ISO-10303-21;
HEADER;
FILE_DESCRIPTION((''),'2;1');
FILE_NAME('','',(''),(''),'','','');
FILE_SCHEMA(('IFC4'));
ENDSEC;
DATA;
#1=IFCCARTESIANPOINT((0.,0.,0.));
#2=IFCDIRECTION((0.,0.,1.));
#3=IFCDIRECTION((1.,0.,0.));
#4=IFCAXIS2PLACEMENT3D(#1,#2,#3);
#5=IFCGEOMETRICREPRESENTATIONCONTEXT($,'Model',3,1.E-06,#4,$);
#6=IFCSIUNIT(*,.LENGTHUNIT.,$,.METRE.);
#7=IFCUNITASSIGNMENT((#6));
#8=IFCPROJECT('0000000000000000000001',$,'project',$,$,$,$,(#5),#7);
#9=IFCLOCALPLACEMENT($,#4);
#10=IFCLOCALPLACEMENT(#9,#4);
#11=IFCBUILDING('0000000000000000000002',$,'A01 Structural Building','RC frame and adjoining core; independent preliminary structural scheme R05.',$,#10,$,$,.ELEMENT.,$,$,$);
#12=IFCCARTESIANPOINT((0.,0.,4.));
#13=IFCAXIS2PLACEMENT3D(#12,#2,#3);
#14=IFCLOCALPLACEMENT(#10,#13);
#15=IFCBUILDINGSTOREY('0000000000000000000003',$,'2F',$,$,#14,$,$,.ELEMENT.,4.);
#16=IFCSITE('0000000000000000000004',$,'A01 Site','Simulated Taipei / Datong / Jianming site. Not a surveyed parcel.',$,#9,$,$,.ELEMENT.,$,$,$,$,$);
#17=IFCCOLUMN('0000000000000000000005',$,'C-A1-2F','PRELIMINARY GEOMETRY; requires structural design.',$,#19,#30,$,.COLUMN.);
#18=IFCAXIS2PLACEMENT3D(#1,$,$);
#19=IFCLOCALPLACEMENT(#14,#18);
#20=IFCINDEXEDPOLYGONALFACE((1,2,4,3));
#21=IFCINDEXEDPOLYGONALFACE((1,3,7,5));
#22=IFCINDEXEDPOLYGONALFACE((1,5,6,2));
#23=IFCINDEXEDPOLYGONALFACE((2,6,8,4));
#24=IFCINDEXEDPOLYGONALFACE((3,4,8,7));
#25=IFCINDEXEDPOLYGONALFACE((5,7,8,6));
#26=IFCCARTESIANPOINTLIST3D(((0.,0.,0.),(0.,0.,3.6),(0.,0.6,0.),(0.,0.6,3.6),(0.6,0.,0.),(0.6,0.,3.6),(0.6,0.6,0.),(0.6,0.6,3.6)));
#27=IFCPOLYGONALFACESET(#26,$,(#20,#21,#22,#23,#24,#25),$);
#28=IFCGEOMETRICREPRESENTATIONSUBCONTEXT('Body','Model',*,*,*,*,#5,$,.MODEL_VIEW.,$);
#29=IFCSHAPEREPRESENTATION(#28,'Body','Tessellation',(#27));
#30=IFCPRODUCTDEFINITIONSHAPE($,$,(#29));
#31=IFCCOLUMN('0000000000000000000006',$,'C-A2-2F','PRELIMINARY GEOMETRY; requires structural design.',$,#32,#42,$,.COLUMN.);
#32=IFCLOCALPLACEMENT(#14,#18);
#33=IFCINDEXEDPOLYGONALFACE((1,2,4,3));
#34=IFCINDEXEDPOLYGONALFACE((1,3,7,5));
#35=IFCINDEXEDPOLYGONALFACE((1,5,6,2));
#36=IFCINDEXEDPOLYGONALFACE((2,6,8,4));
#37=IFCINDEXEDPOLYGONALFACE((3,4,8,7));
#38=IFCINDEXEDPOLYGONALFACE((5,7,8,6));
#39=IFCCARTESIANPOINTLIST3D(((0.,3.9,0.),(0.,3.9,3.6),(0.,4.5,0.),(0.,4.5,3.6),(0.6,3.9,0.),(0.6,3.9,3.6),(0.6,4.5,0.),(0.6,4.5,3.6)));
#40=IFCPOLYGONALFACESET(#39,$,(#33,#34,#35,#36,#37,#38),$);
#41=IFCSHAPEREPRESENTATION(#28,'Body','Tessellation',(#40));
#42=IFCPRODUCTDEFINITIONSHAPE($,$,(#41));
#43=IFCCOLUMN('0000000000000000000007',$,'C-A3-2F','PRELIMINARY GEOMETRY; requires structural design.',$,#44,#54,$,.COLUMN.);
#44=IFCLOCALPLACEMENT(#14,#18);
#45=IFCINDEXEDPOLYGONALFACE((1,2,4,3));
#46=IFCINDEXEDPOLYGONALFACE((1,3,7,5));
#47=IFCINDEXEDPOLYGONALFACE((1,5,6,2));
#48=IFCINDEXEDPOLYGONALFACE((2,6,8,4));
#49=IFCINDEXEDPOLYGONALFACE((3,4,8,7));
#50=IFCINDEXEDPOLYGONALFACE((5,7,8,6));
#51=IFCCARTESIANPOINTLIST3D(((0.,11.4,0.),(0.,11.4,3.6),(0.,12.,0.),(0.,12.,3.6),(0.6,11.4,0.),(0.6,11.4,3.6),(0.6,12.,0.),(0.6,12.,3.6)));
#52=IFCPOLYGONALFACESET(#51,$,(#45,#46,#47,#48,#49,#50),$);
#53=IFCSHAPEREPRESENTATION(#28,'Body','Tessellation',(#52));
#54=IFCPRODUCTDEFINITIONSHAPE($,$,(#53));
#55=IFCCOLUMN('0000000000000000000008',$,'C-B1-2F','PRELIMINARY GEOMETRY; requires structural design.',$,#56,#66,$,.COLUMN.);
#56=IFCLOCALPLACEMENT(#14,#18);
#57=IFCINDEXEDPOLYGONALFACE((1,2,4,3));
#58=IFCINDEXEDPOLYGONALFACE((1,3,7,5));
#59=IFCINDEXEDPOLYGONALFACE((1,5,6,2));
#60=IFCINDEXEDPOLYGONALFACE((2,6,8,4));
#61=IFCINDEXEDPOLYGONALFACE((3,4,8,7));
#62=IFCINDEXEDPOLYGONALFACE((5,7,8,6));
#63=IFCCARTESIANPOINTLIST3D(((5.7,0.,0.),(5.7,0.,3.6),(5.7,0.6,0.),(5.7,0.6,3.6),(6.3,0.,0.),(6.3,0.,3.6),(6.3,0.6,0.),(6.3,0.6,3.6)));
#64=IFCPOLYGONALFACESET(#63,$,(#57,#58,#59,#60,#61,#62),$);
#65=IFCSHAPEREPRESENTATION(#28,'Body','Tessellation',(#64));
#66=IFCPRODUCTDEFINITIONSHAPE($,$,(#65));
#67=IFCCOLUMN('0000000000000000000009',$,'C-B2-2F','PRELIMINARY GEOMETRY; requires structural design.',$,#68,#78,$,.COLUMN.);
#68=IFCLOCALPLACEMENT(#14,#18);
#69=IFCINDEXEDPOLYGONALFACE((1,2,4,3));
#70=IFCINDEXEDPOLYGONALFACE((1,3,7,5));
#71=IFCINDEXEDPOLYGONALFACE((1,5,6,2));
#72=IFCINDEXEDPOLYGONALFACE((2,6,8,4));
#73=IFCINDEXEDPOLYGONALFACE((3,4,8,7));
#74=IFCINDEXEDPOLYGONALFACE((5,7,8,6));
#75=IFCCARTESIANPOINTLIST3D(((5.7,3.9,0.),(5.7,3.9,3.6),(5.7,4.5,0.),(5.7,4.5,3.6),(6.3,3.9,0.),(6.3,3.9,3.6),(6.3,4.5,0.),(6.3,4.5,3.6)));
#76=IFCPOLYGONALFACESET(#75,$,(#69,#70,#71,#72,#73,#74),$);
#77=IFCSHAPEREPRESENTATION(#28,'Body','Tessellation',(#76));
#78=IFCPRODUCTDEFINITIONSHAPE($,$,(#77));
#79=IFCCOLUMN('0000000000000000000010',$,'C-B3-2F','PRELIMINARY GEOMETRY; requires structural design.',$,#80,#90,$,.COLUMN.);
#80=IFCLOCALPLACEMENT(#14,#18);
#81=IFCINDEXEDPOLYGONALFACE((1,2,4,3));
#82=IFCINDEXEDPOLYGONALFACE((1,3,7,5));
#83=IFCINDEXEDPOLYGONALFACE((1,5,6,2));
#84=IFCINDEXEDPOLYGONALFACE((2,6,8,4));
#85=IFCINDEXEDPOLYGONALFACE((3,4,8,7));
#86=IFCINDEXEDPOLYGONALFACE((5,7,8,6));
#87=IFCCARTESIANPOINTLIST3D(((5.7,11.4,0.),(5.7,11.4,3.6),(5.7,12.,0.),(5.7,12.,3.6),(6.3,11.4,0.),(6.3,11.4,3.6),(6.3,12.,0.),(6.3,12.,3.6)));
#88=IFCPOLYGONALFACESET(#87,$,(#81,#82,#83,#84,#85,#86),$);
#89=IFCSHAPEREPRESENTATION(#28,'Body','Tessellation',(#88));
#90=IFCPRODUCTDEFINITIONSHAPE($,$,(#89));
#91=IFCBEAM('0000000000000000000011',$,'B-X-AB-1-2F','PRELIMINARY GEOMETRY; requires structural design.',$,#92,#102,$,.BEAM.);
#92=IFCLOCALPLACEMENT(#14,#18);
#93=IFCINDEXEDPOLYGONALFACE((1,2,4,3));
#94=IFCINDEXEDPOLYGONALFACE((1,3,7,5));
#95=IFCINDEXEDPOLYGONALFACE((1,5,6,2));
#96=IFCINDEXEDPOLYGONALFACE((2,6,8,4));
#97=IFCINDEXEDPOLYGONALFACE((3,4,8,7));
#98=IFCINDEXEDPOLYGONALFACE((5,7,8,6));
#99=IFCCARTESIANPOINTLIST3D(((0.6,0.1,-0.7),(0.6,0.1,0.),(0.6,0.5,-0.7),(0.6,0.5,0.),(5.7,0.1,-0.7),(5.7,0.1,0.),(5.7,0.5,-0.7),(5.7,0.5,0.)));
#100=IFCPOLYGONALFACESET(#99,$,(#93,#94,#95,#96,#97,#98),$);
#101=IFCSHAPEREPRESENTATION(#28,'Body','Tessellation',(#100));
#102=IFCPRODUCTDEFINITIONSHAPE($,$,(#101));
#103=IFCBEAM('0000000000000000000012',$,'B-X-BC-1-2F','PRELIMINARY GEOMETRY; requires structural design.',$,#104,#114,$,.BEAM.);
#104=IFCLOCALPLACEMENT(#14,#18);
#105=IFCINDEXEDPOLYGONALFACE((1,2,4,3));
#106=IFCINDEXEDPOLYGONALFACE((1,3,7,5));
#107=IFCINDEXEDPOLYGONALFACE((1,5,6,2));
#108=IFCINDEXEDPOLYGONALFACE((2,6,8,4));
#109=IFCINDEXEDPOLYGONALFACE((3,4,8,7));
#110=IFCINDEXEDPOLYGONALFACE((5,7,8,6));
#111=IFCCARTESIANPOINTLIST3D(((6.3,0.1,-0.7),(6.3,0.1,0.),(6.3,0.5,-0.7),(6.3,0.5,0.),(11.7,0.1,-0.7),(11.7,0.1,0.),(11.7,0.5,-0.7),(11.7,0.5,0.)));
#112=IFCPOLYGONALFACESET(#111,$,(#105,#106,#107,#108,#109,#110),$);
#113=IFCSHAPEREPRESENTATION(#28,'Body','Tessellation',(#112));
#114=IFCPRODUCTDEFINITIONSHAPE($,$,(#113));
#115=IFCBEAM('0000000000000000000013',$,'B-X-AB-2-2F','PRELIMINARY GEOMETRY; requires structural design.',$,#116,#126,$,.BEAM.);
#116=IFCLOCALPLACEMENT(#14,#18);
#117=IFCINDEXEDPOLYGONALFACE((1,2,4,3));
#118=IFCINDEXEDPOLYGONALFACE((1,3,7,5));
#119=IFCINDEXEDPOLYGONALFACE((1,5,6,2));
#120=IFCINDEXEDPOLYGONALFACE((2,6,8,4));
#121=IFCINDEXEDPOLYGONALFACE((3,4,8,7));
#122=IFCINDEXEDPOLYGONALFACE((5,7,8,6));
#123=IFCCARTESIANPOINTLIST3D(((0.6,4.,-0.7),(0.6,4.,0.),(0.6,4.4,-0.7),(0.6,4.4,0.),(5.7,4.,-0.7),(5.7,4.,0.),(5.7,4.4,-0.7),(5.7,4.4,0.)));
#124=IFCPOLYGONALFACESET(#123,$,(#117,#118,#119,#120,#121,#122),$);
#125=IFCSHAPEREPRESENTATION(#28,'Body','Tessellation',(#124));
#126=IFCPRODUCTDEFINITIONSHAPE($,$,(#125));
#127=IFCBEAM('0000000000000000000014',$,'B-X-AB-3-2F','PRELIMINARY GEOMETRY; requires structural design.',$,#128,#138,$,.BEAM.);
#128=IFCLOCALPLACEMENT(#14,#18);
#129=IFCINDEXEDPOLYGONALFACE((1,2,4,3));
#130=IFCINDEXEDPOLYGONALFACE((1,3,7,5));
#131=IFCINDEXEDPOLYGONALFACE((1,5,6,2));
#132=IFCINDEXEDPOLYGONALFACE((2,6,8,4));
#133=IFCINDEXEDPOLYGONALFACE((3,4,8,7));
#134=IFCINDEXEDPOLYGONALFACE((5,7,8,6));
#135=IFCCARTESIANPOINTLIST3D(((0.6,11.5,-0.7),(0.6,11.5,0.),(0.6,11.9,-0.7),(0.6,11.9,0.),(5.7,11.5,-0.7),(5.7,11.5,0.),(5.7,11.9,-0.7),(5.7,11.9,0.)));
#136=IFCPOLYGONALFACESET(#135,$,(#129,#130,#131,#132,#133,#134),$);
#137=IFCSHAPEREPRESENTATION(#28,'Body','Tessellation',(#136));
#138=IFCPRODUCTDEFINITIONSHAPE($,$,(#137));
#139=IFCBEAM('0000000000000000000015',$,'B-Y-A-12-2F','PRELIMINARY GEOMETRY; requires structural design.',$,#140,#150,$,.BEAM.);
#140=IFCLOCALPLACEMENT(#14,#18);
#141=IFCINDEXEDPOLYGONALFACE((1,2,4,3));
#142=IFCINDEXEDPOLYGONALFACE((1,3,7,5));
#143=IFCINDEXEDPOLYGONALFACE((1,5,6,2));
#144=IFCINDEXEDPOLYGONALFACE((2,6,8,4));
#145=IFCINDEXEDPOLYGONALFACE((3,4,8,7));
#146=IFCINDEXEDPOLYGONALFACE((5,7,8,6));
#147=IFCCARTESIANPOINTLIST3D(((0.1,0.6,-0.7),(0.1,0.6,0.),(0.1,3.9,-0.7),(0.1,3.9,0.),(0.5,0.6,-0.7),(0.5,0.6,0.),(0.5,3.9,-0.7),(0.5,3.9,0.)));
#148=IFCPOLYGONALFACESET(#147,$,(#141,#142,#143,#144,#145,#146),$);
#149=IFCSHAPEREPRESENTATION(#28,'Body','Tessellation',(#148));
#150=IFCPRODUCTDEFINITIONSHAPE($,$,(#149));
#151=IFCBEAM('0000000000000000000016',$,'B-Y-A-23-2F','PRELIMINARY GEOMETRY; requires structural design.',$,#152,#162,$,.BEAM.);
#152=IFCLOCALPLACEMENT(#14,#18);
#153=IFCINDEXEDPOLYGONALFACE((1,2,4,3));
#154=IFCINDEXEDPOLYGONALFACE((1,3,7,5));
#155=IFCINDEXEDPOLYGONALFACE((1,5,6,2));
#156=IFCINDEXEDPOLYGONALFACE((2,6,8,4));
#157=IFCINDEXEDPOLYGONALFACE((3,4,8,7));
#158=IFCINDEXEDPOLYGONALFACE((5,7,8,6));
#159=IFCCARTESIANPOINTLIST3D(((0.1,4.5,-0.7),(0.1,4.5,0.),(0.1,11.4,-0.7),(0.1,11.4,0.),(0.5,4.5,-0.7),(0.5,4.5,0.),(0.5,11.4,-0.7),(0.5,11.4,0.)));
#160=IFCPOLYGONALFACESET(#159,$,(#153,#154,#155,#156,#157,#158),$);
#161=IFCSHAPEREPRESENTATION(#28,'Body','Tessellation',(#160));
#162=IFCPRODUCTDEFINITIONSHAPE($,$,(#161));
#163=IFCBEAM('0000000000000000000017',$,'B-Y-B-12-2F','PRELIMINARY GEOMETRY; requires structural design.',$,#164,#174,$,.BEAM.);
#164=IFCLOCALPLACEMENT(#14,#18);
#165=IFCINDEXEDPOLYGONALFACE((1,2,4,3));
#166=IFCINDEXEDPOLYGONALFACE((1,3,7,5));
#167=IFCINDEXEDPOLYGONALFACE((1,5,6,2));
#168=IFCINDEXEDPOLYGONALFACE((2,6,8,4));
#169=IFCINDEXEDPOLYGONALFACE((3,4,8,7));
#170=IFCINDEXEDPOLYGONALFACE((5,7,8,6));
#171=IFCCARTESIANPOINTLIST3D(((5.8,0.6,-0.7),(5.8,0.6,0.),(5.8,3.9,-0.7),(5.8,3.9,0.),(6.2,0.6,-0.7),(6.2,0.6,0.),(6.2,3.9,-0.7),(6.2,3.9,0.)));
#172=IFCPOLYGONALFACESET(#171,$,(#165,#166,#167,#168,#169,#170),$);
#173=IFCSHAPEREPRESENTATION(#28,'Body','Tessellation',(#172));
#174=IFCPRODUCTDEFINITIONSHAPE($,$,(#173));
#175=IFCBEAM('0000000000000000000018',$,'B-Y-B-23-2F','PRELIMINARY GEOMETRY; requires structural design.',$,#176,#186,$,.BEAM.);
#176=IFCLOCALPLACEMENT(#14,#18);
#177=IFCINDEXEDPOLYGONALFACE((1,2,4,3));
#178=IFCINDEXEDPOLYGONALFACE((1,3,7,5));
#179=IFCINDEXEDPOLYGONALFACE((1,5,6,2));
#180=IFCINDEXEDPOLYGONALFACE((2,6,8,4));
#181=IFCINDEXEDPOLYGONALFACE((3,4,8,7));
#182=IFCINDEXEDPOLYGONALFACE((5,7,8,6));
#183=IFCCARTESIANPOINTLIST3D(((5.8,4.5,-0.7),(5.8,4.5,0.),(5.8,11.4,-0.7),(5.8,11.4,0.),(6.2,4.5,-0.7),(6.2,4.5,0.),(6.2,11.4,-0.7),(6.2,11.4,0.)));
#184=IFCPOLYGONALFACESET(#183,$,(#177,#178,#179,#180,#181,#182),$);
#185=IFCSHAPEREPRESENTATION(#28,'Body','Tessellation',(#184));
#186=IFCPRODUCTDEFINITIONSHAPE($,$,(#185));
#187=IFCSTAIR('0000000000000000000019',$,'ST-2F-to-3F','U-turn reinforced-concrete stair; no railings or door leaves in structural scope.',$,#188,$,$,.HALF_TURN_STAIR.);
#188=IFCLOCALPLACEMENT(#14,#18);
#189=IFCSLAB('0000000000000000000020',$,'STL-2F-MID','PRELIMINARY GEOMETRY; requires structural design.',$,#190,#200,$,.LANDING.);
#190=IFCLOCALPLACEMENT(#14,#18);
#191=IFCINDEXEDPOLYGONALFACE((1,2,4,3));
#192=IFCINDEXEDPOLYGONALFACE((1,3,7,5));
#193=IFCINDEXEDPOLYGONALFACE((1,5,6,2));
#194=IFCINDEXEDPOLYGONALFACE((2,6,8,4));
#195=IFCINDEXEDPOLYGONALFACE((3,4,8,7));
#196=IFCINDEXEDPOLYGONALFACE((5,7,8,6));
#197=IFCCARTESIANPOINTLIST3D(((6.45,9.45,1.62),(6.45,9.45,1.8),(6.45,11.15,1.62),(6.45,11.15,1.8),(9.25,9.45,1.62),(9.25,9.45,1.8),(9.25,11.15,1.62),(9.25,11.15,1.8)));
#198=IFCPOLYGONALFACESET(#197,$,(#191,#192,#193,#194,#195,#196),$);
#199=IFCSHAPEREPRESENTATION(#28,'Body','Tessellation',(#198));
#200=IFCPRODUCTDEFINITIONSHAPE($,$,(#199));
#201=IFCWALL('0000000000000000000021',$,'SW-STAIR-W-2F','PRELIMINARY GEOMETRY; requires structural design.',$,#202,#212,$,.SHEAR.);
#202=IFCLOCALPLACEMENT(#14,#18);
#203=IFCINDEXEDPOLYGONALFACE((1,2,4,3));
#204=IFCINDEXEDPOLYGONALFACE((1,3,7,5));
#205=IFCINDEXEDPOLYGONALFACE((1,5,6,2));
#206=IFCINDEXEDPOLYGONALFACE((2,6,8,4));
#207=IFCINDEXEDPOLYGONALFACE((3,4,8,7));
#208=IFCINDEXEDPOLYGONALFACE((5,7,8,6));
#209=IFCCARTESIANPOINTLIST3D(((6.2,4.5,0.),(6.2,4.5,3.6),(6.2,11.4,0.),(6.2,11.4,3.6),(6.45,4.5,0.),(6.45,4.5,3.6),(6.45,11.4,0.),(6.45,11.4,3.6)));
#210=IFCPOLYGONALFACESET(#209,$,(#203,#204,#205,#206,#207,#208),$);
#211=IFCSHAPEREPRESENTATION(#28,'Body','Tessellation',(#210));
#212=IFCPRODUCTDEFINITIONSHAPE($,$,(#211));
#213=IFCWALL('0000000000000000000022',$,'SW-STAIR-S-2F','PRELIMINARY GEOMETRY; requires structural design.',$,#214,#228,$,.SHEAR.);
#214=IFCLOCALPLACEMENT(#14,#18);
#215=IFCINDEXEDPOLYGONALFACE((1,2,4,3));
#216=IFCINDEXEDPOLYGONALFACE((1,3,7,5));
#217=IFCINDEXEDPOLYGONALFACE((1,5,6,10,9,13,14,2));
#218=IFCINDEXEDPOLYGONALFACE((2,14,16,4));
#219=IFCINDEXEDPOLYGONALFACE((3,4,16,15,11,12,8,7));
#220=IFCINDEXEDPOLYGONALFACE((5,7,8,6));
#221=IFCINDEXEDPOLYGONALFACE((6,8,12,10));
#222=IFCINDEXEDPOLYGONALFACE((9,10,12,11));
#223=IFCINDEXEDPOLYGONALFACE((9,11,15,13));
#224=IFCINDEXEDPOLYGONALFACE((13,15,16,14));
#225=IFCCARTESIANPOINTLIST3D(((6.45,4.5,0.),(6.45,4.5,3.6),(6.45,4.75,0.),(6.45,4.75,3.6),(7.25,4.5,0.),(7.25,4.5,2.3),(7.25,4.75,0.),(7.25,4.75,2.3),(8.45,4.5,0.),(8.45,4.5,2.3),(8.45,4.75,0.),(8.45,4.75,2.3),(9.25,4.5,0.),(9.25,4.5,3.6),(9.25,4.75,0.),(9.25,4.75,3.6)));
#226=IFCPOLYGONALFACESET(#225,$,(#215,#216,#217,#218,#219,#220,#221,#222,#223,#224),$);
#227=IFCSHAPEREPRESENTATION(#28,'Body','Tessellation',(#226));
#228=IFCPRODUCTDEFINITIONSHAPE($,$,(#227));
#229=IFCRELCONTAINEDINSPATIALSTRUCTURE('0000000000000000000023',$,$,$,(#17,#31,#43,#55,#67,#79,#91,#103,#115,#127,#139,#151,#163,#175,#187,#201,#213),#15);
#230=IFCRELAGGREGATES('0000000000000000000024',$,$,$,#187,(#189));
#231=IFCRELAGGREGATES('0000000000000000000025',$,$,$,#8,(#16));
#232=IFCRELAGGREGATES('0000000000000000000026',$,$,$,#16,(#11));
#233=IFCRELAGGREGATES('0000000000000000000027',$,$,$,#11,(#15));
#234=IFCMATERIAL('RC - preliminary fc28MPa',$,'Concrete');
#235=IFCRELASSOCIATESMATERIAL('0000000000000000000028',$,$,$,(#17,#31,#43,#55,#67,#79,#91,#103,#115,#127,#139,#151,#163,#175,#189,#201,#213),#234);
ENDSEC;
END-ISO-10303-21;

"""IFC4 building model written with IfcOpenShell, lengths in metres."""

from ifc_helpers import new_model, si_unit, frame, origin_with_axes, place, context, subcontext, project, spatial, rectangle, extrude, material, element, aggregate, save


model = new_model("IFC4")

# Units and contexts
model_context = context("Model", 3, precision=1e-06, world=origin_with_axes())
body_context = subcontext(model_context, "Body", "Model", "MODEL_VIEW")
ifc_project = project(units=[si_unit("LENGTHUNIT", "METRE")], contexts=[model_context])

# Site, building, storey
site_placement = place(None, origin_with_axes())
site = spatial("IfcSite", under=ifc_project, at=site_placement, Name="A01 Site", Description="Simulated Taipei / Datong / Jianming site. Not a surveyed parcel.", CompositionType="ELEMENT")
building_placement = place(site_placement, origin_with_axes())
building = spatial("IfcBuilding", under=site, at=building_placement, Name="A01 Structural Building", Description="RC frame and adjoining core; independent preliminary structural scheme R05.", CompositionType="ELEMENT")
storey_placement = place(building_placement, frame((0.0, 0.0, 4.0), z_axis=(0.0, 0.0, 1.0), x_axis=(1.0, 0.0, 0.0)))
storey = spatial("IfcBuildingStorey", under=building, at=storey_placement, Name="2F", CompositionType="ELEMENT", Elevation=4.0)

# Columns
ifc_material = material(Name="RC - preliminary fc28MPa", Category="Concrete")
for number, where, z_axis, x_axis, name in (
    (1, (0.3, 0.3, 0.0), (0.0, 0.0, 1.0), (1.0, 0.0, 0.0), "C-A1-2F"),
    (2, (0.3, 4.2, 0.0), (0.0, 0.0, 1.0), (1.0, 0.0, 0.0), "C-A2-2F"),
    (3, (0.3, 11.7, 0.0), (0.0, 0.0, 1.0), (1.0, 0.0, 0.0), "C-A3-2F"),
    (4, (6.0, 0.3, 0.0), (0.0, 0.0, 1.0), (1.0, 0.0, 0.0), "C-B1-2F"),
    (5, (6.0, 4.2, 0.0), (0.0, 0.0, 1.0), (1.0, 0.0, 0.0), "C-B2-2F"),
    (6, (6.0, 11.7, 0.0), (0.0, 0.0, 1.0), (1.0, 0.0, 0.0), "C-B3-2F"),
):
    element("IfcColumn", number, at=place(storey_placement, frame(where, z_axis=z_axis, x_axis=x_axis)), inside=storey, material=ifc_material, Name=name, Description="PRELIMINARY GEOMETRY; requires structural design.", PredefinedType="COLUMN", context=body_context, shape_type="SweptSolid", body=[
        extrude(rectangle(XDim=0.6, YDim=0.6), origin_with_axes(), (0.0, 0.0, 1.0), 3.6),
    ])

# Beams
beam_1_placement = place(storey_placement, frame((3.15, 0.3, -0.7), z_axis=(0.0, 0.0, 1.0), x_axis=(1.0, 0.0, 0.0)))
element("IfcBeam", 7, at=beam_1_placement, inside=storey, material=ifc_material, Name="B-X-AB-1-2F", Description="PRELIMINARY GEOMETRY; requires structural design.", PredefinedType="BEAM", context=body_context, shape_type="SweptSolid", body=[
    extrude(rectangle(XDim=5.1, YDim=0.4), origin_with_axes(), (0.0, 0.0, 1.0), 0.7),
])
beam_2_placement = place(storey_placement, frame((9.0, 0.3, -0.7), z_axis=(0.0, 0.0, 1.0), x_axis=(1.0, 0.0, 0.0)))
element("IfcBeam", 8, at=beam_2_placement, inside=storey, material=ifc_material, Name="B-X-BC-1-2F", Description="PRELIMINARY GEOMETRY; requires structural design.", PredefinedType="BEAM", context=body_context, shape_type="SweptSolid", body=[
    extrude(rectangle(XDim=5.4, YDim=0.4), origin_with_axes(), (0.0, 0.0, 1.0), 0.7),
])
for number, where, z_axis, x_axis, name in (
    (9, (3.15, 4.2, -0.7), (0.0, 0.0, 1.0), (1.0, 0.0, 0.0), "B-X-AB-2-2F"),
    (10, (3.15, 11.7, -0.7), (0.0, 0.0, 1.0), (1.0, 0.0, 0.0), "B-X-AB-3-2F"),
):
    element("IfcBeam", number, at=place(storey_placement, frame(where, z_axis=z_axis, x_axis=x_axis)), inside=storey, material=ifc_material, Name=name, Description="PRELIMINARY GEOMETRY; requires structural design.", PredefinedType="BEAM", context=body_context, shape_type="SweptSolid", body=[
        extrude(rectangle(XDim=5.1, YDim=0.4), origin_with_axes(), (0.0, 0.0, 1.0), 0.7),
    ])
beam_3_placement = place(storey_placement, frame((0.3, 2.25, -0.7), z_axis=(0.0, 0.0, 1.0), x_axis=(1.0, 0.0, 0.0)))
element("IfcBeam", 11, at=beam_3_placement, inside=storey, material=ifc_material, Name="B-Y-A-12-2F", Description="PRELIMINARY GEOMETRY; requires structural design.", PredefinedType="BEAM", context=body_context, shape_type="SweptSolid", body=[
    extrude(rectangle(XDim=0.4, YDim=3.3), origin_with_axes(), (0.0, 0.0, 1.0), 0.7),
])
beam_4_placement = place(storey_placement, frame((0.3, 7.95, -0.7), z_axis=(0.0, 0.0, 1.0), x_axis=(1.0, 0.0, 0.0)))
element("IfcBeam", 12, at=beam_4_placement, inside=storey, material=ifc_material, Name="B-Y-A-23-2F", Description="PRELIMINARY GEOMETRY; requires structural design.", PredefinedType="BEAM", context=body_context, shape_type="SweptSolid", body=[
    extrude(rectangle(XDim=0.4, YDim=6.9), origin_with_axes(), (0.0, 0.0, 1.0), 0.7),
])
beam_5_placement = place(storey_placement, frame((6.0, 2.25, -0.7), z_axis=(0.0, 0.0, 1.0), x_axis=(1.0, 0.0, 0.0)))
element("IfcBeam", 13, at=beam_5_placement, inside=storey, material=ifc_material, Name="B-Y-B-12-2F", Description="PRELIMINARY GEOMETRY; requires structural design.", PredefinedType="BEAM", context=body_context, shape_type="SweptSolid", body=[
    extrude(rectangle(XDim=0.4, YDim=3.3), origin_with_axes(), (0.0, 0.0, 1.0), 0.7),
])
beam_6_placement = place(storey_placement, frame((6.0, 7.95, -0.7), z_axis=(0.0, 0.0, 1.0), x_axis=(1.0, 0.0, 0.0)))
element("IfcBeam", 14, at=beam_6_placement, inside=storey, material=ifc_material, Name="B-Y-B-23-2F", Description="PRELIMINARY GEOMETRY; requires structural design.", PredefinedType="BEAM", context=body_context, shape_type="SweptSolid", body=[
    extrude(rectangle(XDim=0.4, YDim=6.9), origin_with_axes(), (0.0, 0.0, 1.0), 0.7),
])

# Stair, slab
stair_placement = place(storey_placement, origin_with_axes())
stair = element("IfcStair", 15, at=stair_placement, inside=storey, Name="ST-2F-to-3F", Description="U-turn reinforced-concrete stair; no railings or door leaves in structural scope.", PredefinedType="HALF_TURN_STAIR")
slab_placement = place(storey_placement, frame((7.85, 10.3, 1.62), z_axis=(0.0, 0.0, 1.0), x_axis=(1.0, 0.0, 0.0)))
slab = element("IfcSlab", 16, at=slab_placement, material=ifc_material, Name="STL-2F-MID", Description="PRELIMINARY GEOMETRY; requires structural design.", PredefinedType="LANDING", context=body_context, shape_type="SweptSolid", body=[
    extrude(rectangle(XDim=2.8, YDim=1.7), origin_with_axes(), (0.0, 0.0, 1.0), 0.18),
])

# Wall
wall_1_placement = place(storey_placement, frame((6.325, 7.95, 0.0), z_axis=(0.0, 0.0, 1.0), x_axis=(1.0, 0.0, 0.0)))
element("IfcWall", 17, at=wall_1_placement, inside=storey, material=ifc_material, Name="SW-STAIR-W-2F", Description="PRELIMINARY GEOMETRY; requires structural design.", PredefinedType="SHEAR", context=body_context, shape_type="SweptSolid", body=[
    extrude(rectangle(XDim=0.25, YDim=6.9), origin_with_axes(), (0.0, 0.0, 1.0), 3.6),
])

# Wall, opening
wall_2_placement = place(storey_placement, frame((7.85, 4.625, 0.0), z_axis=(0.0, 0.0, 1.0), x_axis=(1.0, 0.0, 0.0)))
wall_2 = element("IfcWall", 18, at=wall_2_placement, inside=storey, material=ifc_material, Name="SW-STAIR-S-2F", Description="PRELIMINARY GEOMETRY; requires structural design.", PredefinedType="SHEAR", context=body_context, shape_type="SweptSolid", body=[
    extrude(rectangle(XDim=2.8, YDim=0.25), origin_with_axes(), (0.0, 0.0, 1.0), 3.6),
])
opening_placement = place(storey_placement, frame((7.85, 4.625, 0.0), z_axis=(0.0, 0.0, 1.0), x_axis=(1.0, 0.0, 0.0)))
element("IfcOpeningElement", 19, at=opening_placement, cuts=wall_2, PredefinedType="OPENING", context=body_context, shape_type="SweptSolid", body=[
    extrude(rectangle(XDim=1.2, YDim=0.45), origin_with_axes(), (0.0, 0.0, 1.0), 2.3),
])

aggregate(stair, [slab])

save(model, "model.ifc")
